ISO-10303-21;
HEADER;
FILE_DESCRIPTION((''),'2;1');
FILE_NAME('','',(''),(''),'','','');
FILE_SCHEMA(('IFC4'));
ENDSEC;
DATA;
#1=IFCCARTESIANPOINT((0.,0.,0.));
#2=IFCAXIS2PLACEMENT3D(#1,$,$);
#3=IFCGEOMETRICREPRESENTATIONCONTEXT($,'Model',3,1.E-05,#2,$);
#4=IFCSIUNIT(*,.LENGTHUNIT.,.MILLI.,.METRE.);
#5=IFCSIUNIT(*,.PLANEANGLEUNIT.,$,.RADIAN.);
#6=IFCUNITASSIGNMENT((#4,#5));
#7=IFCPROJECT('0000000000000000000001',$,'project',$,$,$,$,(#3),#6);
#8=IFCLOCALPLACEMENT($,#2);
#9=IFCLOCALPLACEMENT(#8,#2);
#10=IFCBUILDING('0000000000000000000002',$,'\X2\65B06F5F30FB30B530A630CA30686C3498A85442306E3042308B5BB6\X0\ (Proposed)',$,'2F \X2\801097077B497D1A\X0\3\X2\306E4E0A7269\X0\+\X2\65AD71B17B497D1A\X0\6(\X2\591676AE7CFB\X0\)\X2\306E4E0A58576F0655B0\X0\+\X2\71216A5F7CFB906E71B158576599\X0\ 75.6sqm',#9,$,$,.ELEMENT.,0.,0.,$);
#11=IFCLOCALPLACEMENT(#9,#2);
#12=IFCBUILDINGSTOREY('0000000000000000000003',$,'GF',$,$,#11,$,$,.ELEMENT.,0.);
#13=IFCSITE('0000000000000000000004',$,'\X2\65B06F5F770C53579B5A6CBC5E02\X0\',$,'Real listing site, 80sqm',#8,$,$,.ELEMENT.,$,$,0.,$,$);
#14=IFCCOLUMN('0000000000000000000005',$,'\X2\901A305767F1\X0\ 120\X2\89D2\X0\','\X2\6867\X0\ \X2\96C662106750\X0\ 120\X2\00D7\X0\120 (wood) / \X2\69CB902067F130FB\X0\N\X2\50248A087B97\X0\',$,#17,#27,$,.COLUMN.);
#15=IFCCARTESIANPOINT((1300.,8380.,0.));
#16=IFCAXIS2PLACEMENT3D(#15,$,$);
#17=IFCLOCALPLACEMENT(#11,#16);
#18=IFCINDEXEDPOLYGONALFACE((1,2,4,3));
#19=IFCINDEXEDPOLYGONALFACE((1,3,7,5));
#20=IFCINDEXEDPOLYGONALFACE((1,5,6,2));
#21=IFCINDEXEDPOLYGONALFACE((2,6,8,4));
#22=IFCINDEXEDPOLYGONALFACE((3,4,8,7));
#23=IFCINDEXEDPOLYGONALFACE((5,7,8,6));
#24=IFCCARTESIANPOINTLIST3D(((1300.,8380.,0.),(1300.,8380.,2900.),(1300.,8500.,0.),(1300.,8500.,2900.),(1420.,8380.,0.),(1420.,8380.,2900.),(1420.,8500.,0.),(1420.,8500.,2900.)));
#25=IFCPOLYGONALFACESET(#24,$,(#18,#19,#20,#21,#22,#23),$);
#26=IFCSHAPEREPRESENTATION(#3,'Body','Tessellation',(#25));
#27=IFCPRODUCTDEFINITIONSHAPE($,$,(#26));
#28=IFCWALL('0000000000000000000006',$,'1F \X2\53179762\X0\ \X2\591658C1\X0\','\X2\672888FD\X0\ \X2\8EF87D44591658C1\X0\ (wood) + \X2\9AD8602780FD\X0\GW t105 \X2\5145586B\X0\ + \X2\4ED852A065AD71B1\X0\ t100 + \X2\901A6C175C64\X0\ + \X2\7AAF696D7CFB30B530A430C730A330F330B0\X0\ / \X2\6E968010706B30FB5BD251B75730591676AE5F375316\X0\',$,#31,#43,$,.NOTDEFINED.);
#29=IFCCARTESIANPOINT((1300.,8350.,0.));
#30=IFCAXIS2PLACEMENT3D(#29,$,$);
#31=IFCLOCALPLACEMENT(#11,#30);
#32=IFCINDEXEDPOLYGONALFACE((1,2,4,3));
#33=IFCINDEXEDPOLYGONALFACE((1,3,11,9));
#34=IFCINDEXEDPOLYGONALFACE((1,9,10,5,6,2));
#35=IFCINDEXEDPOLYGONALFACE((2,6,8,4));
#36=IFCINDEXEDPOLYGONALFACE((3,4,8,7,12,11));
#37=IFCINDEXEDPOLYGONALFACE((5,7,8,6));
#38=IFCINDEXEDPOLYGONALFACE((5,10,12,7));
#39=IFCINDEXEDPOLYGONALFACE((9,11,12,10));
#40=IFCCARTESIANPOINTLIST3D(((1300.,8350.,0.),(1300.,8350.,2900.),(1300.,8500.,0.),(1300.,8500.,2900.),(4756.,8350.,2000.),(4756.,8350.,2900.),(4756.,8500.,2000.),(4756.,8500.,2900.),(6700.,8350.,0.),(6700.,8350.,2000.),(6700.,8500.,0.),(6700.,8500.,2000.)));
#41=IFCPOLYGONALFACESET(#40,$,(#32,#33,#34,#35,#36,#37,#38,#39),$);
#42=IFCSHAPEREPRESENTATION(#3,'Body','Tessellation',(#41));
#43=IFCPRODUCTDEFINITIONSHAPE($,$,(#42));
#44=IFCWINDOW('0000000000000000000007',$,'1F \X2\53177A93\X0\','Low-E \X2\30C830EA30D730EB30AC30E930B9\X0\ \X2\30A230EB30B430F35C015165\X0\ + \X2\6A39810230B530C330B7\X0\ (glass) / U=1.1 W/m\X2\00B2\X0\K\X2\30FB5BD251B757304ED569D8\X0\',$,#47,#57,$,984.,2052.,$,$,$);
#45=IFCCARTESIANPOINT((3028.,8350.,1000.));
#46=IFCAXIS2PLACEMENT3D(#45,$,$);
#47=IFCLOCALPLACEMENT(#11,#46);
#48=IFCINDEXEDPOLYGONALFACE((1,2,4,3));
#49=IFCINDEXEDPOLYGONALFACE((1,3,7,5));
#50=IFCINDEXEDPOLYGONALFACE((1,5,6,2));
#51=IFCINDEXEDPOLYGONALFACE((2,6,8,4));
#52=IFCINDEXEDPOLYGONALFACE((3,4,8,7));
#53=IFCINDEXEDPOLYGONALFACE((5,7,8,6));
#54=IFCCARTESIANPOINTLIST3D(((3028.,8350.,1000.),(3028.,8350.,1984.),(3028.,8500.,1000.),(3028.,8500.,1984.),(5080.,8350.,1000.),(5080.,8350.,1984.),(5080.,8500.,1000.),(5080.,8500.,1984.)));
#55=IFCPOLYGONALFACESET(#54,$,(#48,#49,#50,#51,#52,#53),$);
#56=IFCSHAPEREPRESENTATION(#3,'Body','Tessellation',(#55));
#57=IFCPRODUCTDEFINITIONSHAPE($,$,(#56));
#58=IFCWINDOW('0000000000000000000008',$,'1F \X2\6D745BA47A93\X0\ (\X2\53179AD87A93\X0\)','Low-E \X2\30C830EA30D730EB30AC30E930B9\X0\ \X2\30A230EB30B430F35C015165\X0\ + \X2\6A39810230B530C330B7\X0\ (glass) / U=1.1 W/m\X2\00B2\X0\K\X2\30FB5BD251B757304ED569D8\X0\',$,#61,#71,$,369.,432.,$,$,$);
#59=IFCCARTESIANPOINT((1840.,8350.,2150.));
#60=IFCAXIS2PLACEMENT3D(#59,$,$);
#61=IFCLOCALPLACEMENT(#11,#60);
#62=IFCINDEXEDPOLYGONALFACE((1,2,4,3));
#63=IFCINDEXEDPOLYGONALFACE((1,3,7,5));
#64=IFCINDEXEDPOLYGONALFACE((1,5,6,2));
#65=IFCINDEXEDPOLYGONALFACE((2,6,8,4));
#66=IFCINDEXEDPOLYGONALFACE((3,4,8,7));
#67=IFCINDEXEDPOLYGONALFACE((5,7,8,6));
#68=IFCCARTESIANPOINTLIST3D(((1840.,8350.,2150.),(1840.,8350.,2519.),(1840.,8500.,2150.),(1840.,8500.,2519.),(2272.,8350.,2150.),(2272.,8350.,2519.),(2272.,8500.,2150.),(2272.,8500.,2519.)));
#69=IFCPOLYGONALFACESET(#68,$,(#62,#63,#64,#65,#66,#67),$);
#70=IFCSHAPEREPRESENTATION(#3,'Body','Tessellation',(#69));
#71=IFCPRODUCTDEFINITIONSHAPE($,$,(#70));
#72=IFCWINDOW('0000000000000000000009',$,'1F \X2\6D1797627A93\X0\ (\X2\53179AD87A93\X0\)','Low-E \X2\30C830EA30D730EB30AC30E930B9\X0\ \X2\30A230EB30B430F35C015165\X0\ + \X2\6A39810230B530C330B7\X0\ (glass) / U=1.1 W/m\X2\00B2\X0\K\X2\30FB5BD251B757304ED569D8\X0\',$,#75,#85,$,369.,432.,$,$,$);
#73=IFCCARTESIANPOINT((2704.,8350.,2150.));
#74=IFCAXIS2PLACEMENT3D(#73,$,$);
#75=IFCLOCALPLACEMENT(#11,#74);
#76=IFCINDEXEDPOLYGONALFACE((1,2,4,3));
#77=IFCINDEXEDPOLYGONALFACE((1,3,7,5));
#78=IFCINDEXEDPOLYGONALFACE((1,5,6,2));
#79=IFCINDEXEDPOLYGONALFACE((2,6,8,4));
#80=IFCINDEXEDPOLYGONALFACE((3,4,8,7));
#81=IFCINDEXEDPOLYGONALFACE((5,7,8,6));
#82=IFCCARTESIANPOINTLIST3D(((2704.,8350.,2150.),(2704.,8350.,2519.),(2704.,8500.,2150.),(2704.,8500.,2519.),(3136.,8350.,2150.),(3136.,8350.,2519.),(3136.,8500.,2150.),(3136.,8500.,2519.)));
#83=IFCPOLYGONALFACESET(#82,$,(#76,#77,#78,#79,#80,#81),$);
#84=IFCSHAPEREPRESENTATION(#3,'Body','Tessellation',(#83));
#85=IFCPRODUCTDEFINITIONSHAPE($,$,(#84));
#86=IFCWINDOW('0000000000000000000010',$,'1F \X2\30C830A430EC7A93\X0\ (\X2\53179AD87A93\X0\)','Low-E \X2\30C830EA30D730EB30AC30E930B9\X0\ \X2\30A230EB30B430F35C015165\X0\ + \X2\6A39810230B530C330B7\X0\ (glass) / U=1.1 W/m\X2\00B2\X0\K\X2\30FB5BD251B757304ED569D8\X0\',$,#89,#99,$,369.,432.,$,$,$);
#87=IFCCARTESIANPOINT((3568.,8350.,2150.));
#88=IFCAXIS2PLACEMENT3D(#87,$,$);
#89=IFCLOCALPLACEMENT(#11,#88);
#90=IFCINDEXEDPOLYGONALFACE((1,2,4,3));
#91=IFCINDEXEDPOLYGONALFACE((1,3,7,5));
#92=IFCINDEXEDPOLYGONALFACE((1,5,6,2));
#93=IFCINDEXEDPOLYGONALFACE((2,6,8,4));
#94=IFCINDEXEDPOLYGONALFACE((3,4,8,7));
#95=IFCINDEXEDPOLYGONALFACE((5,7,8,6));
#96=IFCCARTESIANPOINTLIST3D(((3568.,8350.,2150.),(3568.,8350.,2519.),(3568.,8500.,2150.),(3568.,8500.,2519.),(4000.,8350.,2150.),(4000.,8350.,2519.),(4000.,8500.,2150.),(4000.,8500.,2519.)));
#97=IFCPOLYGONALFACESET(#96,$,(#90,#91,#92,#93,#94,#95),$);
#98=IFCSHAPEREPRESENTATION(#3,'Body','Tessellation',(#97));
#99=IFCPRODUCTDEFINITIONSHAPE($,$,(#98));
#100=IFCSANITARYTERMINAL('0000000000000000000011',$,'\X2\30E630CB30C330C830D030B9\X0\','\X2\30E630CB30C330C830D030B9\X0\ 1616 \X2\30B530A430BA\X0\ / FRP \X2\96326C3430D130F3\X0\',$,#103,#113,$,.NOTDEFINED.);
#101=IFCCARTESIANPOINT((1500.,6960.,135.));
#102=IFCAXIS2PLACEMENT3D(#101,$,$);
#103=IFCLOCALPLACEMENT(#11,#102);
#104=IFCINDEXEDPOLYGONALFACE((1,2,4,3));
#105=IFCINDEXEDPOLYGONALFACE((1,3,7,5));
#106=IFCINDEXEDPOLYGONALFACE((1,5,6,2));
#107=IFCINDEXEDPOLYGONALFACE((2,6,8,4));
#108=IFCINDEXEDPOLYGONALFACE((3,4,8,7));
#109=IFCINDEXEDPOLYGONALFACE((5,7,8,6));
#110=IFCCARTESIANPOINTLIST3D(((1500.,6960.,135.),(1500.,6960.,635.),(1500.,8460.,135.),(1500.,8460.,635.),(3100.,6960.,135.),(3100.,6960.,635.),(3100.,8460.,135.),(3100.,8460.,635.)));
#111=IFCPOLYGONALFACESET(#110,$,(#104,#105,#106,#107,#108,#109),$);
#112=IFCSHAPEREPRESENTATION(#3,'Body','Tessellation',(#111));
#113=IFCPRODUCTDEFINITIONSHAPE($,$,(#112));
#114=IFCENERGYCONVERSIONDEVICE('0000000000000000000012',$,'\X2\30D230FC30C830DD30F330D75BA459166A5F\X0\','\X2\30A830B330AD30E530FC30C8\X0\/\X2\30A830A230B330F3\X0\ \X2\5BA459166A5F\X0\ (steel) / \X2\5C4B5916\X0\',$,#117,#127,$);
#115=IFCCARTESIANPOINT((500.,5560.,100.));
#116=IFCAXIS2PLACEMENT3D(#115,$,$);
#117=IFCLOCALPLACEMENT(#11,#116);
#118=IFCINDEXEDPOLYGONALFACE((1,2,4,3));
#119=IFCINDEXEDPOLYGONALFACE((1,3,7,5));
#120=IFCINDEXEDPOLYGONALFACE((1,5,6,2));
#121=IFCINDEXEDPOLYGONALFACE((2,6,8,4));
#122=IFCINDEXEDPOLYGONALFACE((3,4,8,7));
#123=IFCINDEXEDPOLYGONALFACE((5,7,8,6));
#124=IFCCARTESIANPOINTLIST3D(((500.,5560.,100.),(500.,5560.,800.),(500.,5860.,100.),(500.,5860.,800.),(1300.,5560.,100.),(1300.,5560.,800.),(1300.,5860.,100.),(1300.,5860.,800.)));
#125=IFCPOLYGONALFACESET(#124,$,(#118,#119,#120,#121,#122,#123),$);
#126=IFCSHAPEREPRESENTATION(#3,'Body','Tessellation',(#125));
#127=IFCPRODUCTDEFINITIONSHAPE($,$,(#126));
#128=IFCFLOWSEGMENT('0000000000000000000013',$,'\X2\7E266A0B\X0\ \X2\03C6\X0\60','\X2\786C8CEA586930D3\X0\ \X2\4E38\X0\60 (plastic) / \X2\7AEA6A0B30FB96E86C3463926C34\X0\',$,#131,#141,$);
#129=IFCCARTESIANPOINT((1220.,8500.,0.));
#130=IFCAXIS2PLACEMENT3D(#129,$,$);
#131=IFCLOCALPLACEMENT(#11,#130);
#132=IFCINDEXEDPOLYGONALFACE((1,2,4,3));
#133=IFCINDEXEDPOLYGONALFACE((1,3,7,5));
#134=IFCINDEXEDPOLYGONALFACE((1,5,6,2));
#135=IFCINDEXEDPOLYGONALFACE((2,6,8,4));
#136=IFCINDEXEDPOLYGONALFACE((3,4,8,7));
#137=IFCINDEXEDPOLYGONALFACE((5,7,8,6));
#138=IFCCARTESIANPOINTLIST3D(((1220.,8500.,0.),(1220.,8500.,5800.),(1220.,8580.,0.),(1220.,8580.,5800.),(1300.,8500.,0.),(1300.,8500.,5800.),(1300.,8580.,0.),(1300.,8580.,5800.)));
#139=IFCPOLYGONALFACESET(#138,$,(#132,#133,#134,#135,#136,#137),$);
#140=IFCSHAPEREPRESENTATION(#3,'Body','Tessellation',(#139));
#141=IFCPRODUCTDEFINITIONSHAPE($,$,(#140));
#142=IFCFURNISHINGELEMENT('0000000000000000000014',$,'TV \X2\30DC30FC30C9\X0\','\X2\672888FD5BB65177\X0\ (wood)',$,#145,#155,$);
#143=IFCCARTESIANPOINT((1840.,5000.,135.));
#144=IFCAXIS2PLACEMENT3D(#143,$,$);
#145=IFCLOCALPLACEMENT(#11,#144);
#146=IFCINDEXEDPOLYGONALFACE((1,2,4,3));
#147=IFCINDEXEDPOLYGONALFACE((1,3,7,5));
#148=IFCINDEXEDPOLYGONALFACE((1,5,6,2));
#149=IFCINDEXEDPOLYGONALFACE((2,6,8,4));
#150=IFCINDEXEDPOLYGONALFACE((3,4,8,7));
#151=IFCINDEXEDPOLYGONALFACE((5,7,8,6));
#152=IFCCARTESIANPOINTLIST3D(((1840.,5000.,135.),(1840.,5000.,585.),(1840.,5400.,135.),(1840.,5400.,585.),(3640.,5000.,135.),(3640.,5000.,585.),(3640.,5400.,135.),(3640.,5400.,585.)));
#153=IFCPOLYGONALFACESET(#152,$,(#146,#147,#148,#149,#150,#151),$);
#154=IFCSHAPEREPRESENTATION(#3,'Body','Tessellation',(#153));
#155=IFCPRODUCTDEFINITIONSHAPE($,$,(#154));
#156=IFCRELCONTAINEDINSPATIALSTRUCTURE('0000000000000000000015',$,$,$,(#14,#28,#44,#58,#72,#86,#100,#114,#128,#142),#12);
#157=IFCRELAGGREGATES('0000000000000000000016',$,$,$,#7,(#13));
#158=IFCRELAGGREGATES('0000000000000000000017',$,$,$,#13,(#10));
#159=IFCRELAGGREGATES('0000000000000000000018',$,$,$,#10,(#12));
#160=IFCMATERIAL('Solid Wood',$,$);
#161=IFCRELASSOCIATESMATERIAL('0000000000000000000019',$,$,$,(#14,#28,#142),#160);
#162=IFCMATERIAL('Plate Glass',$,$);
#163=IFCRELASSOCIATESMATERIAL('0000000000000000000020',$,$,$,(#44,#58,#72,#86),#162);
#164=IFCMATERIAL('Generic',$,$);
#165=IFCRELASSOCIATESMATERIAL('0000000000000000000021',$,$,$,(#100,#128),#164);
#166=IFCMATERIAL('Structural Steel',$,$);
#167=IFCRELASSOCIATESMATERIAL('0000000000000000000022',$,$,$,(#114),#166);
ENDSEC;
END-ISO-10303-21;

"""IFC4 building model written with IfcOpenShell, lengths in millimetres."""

from ifc_helpers import new_model, si_unit, frame, frame_2d, origin, place, context, project, spatial, rectangle, extrude, material, element, fill, save


model = new_model("IFC4")

# Units and contexts
model_context = context("Model", 3, precision=1e-05, world=origin())
ifc_project = project(units=[si_unit("LENGTHUNIT", "METRE", prefix="MILLI"), si_unit("PLANEANGLEUNIT", "RADIAN")], contexts=[model_context])

# Site, building, storey
site_placement = place(None, origin())
site = spatial("IfcSite", under=ifc_project, at=site_placement, Name="新潟県南魚沼市", ObjectType="Real listing site, 80sqm", CompositionType="ELEMENT", RefElevation=0.0)
building_placement = place(site_placement, origin())
building = spatial("IfcBuilding", under=site, at=building_placement, Name="新潟・サウナと水風呂のある家 (Proposed)", ObjectType="2F 耐震等級3の上物+断熱等級6(外皮系)の上塗漆喰+無機系遮熱塗料 75.6sqm", CompositionType="ELEMENT", ElevationOfRefHeight=0.0, ElevationOfTerrain=0.0)
storey_placement = place(building_placement, origin())
storey = spatial("IfcBuildingStorey", under=building, at=storey_placement, Name="GF", CompositionType="ELEMENT", Elevation=0.0)

# Column
ifc_material_1 = material(Name="Solid Wood")
column_1_placement = place(storey_placement, frame((1300.0, 8380.0, 0.0)))
element("IfcColumn", 1, at=column_1_placement, inside=storey, material=ifc_material_1, Name="通し柱 120角", Description="桧 集成材 120×120 (wood) / 構造柱・N値計算", PredefinedType="COLUMN", context=model_context, shape_type="SweptSolid", body=[
    extrude(rectangle(XDim=120.0, YDim=120.0, at=frame_2d((60.0, 60.0))), frame((1300.0, 8380.0, 0.0)), (0.0, 0.0, 1.0), 2900.0),
])

# Wall, openings, windows
wall_1_placement = place(storey_placement, frame((1300.0, 8350.0, 0.0)))
wall_1 = element("IfcWall", 2, at=wall_1_placement, inside=storey, material=ifc_material_1, Name="1F 北面 外壁", Description="木製 軸組外壁 (wood) + 高性能GW t105 充填 + 付加断熱 t100 + 通気層 + 窯業系サイディング / 準耐火・寒冷地外皮強化", PredefinedType="NOTDEFINED", context=model_context, shape_type="SweptSolid", body=[
    extrude(rectangle(XDim=5400.0, YDim=150.0, at=frame_2d((2700.0, 75.0))), frame((1300.0, 8350.0, 0.0)), (0.0, 0.0, 1.0), 2900.0),
])
opening_1_placement = place(storey_placement, frame((3028.0, 8350.0, 1000.0)))
opening_1 = element("IfcOpeningElement", 3, at=opening_1_placement, cuts=wall_1, PredefinedType="NOTDEFINED", context=model_context, shape_type="SweptSolid", body=[
    extrude(rectangle(XDim=2052.0, YDim=150.0, at=frame_2d((1026.0, 75.0))), frame((3028.0, 8350.0, 1000.0)), (0.0, 0.0, 1.0), 984.0),
])
opening_2_placement = place(storey_placement, frame((1840.0, 8350.0, 2150.0)))
opening_2 = element("IfcOpeningElement", 4, at=opening_2_placement, cuts=wall_1, PredefinedType="NOTDEFINED", context=model_context, shape_type="SweptSolid", body=[
    extrude(rectangle(XDim=432.0, YDim=150.0, at=frame_2d((216.0, 75.0))), frame((1840.0, 8350.0, 2150.0)), (0.0, 0.0, 1.0), 369.0),
])
opening_3_placement = place(storey_placement, frame((2704.0, 8350.0, 2150.0)))
opening_3 = element("IfcOpeningElement", 5, at=opening_3_placement, cuts=wall_1, PredefinedType="NOTDEFINED", context=model_context, shape_type="SweptSolid", body=[
    extrude(rectangle(XDim=432.0, YDim=150.0, at=frame_2d((216.0, 75.0))), frame((2704.0, 8350.0, 2150.0)), (0.0, 0.0, 1.0), 369.0),
])
opening_4_placement = place(storey_placement, frame((3568.0, 8350.0, 2150.0)))
opening_4 = element("IfcOpeningElement", 6, at=opening_4_placement, cuts=wall_1, PredefinedType="NOTDEFINED", context=model_context, shape_type="SweptSolid", body=[
    extrude(rectangle(XDim=432.0, YDim=150.0, at=frame_2d((216.0, 75.0))), frame((3568.0, 8350.0, 2150.0)), (0.0, 0.0, 1.0), 369.0),
])
ifc_material_2 = material(Name="Plate Glass")
window_1_placement = place(storey_placement, frame((3028.0, 8350.0, 1000.0)))
window_1 = element("IfcWindow", 7, at=window_1_placement, inside=storey, material=ifc_material_2, Name="1F 北窓", Description="Low-E トリプルガラス アルゴン封入 + 樹脂サッシ (glass) / U=1.1 W/m²K・寒冷地仕様", OverallHeight=984.0, OverallWidth=2052.0, context=model_context, shape_type="SweptSolid", body=[
    extrude(rectangle(XDim=2052.0, YDim=150.0, at=frame_2d((1026.0, 75.0))), frame((3028.0, 8350.0, 1000.0)), (0.0, 0.0, 1.0), 984.0),
])
fill(opening_1, window_1)
window_2_placement = place(storey_placement, frame((1840.0, 8350.0, 2150.0)))
window_2 = element("IfcWindow", 8, at=window_2_placement, inside=storey, material=ifc_material_2, Name="1F 浴室窓 (北高窓)", Description="Low-E トリプルガラス アルゴン封入 + 樹脂サッシ (glass) / U=1.1 W/m²K・寒冷地仕様", OverallHeight=369.0, OverallWidth=432.0, context=model_context, shape_type="SweptSolid", body=[
    extrude(rectangle(XDim=432.0, YDim=150.0, at=frame_2d((216.0, 75.0))), frame((1840.0, 8350.0, 2150.0)), (0.0, 0.0, 1.0), 369.0),
])
fill(opening_2, window_2)
window_3_placement = place(storey_placement, frame((2704.0, 8350.0, 2150.0)))
window_3 = element("IfcWindow", 9, at=window_3_placement, inside=storey, material=ifc_material_2, Name="1F 洗面窓 (北高窓)", Description="Low-E トリプルガラス アルゴン封入 + 樹脂サッシ (glass) / U=1.1 W/m²K・寒冷地仕様", OverallHeight=369.0, OverallWidth=432.0, context=model_context, shape_type="SweptSolid", body=[
    extrude(rectangle(XDim=432.0, YDim=150.0, at=frame_2d((216.0, 75.0))), frame((2704.0, 8350.0, 2150.0)), (0.0, 0.0, 1.0), 369.0),
])
fill(opening_3, window_3)
window_4_placement = place(storey_placement, frame((3568.0, 8350.0, 2150.0)))
window_4 = element("IfcWindow", 10, at=window_4_placement, inside=storey, material=ifc_material_2, Name="1F トイレ窓 (北高窓)", Description="Low-E トリプルガラス アルゴン封入 + 樹脂サッシ (glass) / U=1.1 W/m²K・寒冷地仕様", OverallHeight=369.0, OverallWidth=432.0, context=model_context, shape_type="SweptSolid", body=[
    extrude(rectangle(XDim=432.0, YDim=150.0, at=frame_2d((216.0, 75.0))), frame((3568.0, 8350.0, 2150.0)), (0.0, 0.0, 1.0), 369.0),
])
fill(opening_4, window_4)

# Sanitary terminal
ifc_material_3 = material(Name="Generic")
sanitary_terminal_placement = place(storey_placement, frame((1500.0, 6960.0, 135.0)))
element("IfcSanitaryTerminal", 11, at=sanitary_terminal_placement, inside=storey, material=ifc_material_3, Name="ユニットバス", Description="ユニットバス 1616 サイズ / FRP 防水パン", PredefinedType="NOTDEFINED", context=model_context, shape_type="SweptSolid", body=[
    extrude(rectangle(XDim=1600.0, YDim=1500.0, at=frame_2d((800.0, 750.0))), frame((1500.0, 6960.0, 135.0)), (0.0, 0.0, 1.0), 500.0),
])

# Shared definitions
ifc_material_4 = material(Name="Structural Steel")

# Energy conversion device
energy_conversion_device_placement = place(storey_placement, frame((500.0, 5560.0, 100.0)))
element("IfcEnergyConversionDevice", 12, at=energy_conversion_device_placement, inside=storey, material=ifc_material_4, Name="ヒートポンプ室外機", Description="エコキュート/エアコン 室外機 (steel) / 屋外", context=model_context, shape_type="SweptSolid", body=[
    extrude(rectangle(XDim=800.0, YDim=300.0, at=frame_2d((400.0, 150.0))), frame((500.0, 5560.0, 100.0)), (0.0, 0.0, 1.0), 700.0),
])

# Flow segment
flow_segment_placement = place(storey_placement, frame((1220.0, 8500.0, 0.0)))
element("IfcFlowSegment", 13, at=flow_segment_placement, inside=storey, material=ifc_material_3, Name="縦樋 φ60", Description="硬質塩ビ 丸60 (plastic) / 竪樋・雨水排水", context=model_context, shape_type="SweptSolid", body=[
    extrude(rectangle(XDim=80.0, YDim=80.0, at=frame_2d((40.0, 40.0))), frame((1220.0, 8500.0, 0.0)), (0.0, 0.0, 1.0), 5800.0),
])

# Furnishing element
furnishing_1_placement = place(storey_placement, frame((1840.0, 5000.0, 135.0)))
element("IfcFurnishingElement", 14, at=furnishing_1_placement, inside=storey, material=ifc_material_1, Name="TV ボード", Description="木製家具 (wood)", context=model_context, shape_type="SweptSolid", body=[
    extrude(rectangle(XDim=1800.0, YDim=400.0, at=frame_2d((900.0, 200.0))), frame((1840.0, 5000.0, 135.0)), (0.0, 0.0, 1.0), 450.0),
])

save(model, "model.ifc")
